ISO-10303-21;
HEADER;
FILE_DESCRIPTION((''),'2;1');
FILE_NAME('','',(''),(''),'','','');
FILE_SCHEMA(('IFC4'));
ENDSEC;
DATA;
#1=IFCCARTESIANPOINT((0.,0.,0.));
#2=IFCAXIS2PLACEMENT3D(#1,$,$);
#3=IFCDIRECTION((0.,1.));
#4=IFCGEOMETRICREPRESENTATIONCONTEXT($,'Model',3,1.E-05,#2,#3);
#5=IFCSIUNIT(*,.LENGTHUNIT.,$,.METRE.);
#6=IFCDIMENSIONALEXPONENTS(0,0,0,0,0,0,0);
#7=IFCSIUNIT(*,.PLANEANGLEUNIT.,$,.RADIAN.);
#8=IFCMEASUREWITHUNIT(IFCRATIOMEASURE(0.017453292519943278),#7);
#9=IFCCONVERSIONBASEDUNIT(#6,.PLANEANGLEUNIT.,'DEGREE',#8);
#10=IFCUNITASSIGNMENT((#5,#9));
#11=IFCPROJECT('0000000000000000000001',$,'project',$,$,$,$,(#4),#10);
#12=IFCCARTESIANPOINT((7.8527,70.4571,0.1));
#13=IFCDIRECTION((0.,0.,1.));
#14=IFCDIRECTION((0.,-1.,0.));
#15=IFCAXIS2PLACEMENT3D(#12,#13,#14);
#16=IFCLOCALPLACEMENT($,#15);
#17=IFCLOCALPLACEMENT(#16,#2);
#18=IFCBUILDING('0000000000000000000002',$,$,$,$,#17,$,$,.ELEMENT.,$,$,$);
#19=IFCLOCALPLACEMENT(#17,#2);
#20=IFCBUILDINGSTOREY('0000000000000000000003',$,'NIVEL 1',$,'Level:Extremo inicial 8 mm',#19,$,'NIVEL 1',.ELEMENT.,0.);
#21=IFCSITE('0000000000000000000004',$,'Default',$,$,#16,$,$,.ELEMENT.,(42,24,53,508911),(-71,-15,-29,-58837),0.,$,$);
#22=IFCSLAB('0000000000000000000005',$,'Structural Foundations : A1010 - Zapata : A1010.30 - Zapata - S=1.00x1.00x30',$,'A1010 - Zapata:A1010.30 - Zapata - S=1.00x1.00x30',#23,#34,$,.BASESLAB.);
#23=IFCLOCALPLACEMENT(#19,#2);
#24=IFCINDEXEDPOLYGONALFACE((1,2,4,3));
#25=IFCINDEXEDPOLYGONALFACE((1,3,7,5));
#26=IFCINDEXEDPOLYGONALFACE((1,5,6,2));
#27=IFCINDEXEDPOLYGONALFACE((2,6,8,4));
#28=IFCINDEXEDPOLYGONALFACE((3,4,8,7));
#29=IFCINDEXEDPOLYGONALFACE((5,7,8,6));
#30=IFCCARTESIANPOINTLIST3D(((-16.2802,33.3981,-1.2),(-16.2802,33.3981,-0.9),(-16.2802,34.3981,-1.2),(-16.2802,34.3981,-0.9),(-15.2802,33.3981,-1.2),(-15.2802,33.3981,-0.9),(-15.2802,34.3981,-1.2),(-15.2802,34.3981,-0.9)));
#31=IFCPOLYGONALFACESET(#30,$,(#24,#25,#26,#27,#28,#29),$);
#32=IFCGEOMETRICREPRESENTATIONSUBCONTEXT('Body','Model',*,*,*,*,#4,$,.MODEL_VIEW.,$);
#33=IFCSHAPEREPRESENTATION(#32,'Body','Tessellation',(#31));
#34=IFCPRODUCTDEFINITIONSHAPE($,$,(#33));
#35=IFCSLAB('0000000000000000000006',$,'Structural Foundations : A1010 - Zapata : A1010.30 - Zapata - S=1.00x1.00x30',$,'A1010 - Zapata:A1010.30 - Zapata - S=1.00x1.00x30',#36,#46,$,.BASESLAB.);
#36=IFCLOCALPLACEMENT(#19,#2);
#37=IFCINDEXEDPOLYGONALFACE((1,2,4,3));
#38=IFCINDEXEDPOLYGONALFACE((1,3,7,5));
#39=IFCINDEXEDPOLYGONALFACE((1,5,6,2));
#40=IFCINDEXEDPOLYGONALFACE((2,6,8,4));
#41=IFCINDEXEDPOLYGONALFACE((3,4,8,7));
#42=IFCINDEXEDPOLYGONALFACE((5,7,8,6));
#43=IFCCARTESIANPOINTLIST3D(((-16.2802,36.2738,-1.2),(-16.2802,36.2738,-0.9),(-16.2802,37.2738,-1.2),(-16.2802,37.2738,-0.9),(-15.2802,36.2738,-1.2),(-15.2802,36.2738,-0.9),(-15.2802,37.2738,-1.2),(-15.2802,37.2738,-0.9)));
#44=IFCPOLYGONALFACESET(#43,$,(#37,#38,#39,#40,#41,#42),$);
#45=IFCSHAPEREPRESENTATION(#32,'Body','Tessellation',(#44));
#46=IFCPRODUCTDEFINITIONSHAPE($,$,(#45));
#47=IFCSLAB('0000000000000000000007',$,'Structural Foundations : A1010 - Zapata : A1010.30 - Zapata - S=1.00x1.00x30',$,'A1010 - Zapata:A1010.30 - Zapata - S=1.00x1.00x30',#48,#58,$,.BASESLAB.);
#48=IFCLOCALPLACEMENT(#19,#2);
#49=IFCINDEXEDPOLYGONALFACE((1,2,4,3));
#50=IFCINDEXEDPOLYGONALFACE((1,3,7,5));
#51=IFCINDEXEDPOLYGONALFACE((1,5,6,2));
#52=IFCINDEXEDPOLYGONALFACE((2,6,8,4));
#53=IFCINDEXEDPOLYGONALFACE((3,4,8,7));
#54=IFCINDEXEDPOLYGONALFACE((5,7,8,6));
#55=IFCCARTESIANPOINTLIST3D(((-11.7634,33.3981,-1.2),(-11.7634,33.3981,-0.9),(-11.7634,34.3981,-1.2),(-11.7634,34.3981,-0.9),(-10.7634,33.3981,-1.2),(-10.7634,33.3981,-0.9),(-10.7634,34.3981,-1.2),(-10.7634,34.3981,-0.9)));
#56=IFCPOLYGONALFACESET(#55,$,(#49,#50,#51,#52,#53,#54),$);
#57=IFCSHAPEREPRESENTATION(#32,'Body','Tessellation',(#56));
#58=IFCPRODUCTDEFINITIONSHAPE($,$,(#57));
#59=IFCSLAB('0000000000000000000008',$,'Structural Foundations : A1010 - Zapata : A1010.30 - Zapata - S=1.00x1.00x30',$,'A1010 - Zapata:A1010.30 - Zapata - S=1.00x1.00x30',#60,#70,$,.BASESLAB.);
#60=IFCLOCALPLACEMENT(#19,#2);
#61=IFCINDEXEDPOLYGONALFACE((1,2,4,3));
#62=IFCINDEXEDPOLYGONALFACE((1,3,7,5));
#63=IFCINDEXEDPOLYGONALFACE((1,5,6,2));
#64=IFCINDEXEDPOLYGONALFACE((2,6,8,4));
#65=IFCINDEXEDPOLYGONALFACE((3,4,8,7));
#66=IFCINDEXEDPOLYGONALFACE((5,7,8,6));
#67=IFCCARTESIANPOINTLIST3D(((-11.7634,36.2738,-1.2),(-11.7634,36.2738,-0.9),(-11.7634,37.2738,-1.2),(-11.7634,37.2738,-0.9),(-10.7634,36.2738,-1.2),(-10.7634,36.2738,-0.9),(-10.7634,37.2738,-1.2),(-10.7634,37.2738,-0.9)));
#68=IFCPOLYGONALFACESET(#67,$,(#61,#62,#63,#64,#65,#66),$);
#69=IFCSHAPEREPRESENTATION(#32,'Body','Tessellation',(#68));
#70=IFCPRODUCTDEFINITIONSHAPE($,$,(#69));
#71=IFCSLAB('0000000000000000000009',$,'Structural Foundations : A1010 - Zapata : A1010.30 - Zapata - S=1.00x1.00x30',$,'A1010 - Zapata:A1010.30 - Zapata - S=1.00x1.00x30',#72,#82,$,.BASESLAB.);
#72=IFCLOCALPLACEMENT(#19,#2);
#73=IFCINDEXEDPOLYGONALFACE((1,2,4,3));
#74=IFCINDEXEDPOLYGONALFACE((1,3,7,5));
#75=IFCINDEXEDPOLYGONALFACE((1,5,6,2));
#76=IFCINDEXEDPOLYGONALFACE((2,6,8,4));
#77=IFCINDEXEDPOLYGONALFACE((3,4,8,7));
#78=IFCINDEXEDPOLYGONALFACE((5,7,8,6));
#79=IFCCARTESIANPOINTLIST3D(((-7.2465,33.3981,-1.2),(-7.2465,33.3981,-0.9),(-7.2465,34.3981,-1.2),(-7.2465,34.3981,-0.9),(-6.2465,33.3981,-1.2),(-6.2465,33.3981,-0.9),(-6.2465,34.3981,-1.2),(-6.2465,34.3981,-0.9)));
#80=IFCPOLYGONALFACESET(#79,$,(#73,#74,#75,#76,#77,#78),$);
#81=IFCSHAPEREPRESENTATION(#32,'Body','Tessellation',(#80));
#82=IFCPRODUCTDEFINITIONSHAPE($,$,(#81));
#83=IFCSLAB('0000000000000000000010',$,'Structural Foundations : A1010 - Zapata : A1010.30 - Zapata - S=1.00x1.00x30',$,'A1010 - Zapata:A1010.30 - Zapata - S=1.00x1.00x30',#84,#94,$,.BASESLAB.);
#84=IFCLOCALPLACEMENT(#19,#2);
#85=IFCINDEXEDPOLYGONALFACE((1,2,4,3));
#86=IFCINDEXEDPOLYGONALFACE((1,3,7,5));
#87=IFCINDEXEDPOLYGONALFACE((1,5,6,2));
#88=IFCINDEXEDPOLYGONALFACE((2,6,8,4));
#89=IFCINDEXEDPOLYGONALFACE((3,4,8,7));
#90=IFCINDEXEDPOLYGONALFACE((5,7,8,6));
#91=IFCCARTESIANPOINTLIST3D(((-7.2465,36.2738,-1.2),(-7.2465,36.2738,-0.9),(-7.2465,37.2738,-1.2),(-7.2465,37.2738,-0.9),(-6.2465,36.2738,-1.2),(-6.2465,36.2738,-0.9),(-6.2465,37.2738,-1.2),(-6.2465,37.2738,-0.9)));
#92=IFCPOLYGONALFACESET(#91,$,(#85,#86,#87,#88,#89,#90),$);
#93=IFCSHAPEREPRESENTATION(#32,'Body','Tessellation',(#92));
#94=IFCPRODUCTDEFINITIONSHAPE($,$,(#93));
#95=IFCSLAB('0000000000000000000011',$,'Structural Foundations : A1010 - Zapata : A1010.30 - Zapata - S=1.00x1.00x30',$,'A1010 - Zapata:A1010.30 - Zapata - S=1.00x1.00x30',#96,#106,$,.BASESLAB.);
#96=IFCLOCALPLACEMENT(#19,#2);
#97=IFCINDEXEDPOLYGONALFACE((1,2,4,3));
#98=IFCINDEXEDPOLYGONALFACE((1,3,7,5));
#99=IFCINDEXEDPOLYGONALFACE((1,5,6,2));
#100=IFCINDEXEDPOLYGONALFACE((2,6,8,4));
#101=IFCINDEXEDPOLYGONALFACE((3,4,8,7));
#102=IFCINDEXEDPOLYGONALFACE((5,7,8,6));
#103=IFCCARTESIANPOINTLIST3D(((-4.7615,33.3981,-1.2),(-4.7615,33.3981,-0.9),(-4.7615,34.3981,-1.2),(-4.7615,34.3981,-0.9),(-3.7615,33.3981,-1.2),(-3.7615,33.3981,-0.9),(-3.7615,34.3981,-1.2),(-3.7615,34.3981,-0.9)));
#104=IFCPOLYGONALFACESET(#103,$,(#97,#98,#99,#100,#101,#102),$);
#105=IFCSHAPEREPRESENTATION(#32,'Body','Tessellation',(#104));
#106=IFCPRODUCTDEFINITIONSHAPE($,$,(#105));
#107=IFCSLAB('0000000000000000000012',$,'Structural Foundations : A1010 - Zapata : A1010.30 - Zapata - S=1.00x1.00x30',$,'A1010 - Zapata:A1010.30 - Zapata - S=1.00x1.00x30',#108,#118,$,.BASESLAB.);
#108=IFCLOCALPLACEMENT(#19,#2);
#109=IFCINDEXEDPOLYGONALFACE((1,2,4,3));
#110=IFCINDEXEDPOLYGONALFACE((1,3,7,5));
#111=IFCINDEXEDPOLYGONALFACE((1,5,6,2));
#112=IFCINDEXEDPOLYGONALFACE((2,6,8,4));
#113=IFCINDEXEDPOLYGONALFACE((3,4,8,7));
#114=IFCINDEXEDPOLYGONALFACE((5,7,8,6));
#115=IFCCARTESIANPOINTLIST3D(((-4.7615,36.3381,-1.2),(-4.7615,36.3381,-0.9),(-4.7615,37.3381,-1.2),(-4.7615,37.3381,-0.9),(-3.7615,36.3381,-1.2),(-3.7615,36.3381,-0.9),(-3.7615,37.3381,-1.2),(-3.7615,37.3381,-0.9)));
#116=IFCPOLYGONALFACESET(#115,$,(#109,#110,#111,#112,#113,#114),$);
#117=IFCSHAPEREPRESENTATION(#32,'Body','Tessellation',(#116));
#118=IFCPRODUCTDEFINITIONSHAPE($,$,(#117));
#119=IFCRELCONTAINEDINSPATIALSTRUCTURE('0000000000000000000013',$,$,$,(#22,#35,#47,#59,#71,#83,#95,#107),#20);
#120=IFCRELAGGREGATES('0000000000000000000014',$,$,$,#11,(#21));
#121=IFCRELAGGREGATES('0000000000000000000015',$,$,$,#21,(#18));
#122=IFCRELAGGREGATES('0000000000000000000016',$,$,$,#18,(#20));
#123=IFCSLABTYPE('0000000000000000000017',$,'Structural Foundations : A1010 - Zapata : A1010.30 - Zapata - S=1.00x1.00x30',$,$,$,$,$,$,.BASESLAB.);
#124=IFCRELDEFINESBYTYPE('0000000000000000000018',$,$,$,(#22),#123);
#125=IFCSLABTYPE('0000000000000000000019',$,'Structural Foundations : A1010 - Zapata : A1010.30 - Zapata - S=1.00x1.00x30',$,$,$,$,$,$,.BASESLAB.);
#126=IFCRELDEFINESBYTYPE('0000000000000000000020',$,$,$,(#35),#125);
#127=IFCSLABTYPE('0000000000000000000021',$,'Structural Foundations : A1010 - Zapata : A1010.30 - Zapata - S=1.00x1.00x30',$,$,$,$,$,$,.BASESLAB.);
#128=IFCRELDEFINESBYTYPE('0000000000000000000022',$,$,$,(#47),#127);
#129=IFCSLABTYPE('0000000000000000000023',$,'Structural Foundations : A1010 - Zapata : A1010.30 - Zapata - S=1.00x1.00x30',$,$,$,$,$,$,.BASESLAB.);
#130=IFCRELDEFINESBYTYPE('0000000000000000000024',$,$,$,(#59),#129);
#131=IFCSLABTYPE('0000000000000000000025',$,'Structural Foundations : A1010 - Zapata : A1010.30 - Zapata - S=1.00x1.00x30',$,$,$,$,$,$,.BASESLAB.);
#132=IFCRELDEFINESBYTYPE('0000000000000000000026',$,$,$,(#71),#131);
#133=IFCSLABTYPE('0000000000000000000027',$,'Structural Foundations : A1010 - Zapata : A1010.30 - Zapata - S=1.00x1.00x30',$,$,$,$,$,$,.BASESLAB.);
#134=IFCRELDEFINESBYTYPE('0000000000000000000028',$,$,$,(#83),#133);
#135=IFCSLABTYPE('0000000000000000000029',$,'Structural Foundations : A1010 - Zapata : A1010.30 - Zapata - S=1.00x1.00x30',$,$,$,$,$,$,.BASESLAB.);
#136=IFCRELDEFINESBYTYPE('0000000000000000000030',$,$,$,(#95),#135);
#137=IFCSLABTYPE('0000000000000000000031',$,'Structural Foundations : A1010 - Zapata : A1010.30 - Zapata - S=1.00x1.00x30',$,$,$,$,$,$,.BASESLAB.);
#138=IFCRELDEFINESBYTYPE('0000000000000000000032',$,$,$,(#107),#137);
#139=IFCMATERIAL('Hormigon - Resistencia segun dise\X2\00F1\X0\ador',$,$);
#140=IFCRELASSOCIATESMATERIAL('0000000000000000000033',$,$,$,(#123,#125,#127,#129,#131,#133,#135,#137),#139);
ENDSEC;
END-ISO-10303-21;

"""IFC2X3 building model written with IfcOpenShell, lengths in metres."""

from ifc_helpers import new_model, entity, si_unit, converted_unit, direction, frame, frame_2d, origin, origin_2d_with_axis, place, context, subcontext, project, spatial, rectangle, extrude, material, type_object, element, save


model = new_model("IFC2X3")

# Units and contexts
model_context = context("Model", 3, precision=1e-05, world=origin(), true_north=direction((0.0, 1.0)))
body_context = subcontext(model_context, "Body", "Model", "MODEL_VIEW")
ifc_project = project(units=[si_unit("LENGTHUNIT", "METRE"), converted_unit("PLANEANGLEUNIT", "DEGREE", entity("IfcRatioMeasure", 0.017453292519943278), si_unit("PLANEANGLEUNIT", "RADIAN"), dimensions=[0, 0, 0, 0, 0, 0, 0])], contexts=[model_context])

# Site, building, storey
site_placement = place(None, frame((7.8527, 70.4571, 0.1), z_axis=(0.0, 0.0, 1.0), x_axis=(0.0, -1.0, 0.0)))
site = spatial("IfcSite", under=ifc_project, at=site_placement, Name="Default", CompositionType="ELEMENT", RefLatitude=(42, 24, 53, 508911), RefLongitude=(-71, -15, -29, -58837), RefElevation=0.0)
building_placement = place(site_placement, origin())
building = spatial("IfcBuilding", under=site, at=building_placement, CompositionType="ELEMENT")
storey_placement = place(building_placement, origin())
storey = spatial("IfcBuildingStorey", under=building, at=storey_placement, Name="NIVEL 1", ObjectType="Level:Extremo inicial 8 mm", LongName="NIVEL 1", CompositionType="ELEMENT", Elevation=0.0)

# Slabs
ifc_material = material(Name="Hormigon - Resistencia segun diseñador")
slab_type_1 = type_object("IfcSlabType", Name="Structural Foundations : A1010 - Zapata : A1010.30 - Zapata - S=1.00x1.00x30", PredefinedType="BASESLAB", material=ifc_material)
slab_1_placement = place(storey_placement, origin())
element("IfcSlab", 1, at=slab_1_placement, inside=storey, type_object=slab_type_1, Name="Structural Foundations : A1010 - Zapata : A1010.30 - Zapata - S=1.00x1.00x30", ObjectType="A1010 - Zapata:A1010.30 - Zapata - S=1.00x1.00x30", PredefinedType="BASESLAB", context=body_context, shape_type="SweptSolid", body=[
    extrude(rectangle(XDim=1.0, YDim=1.0, at=frame_2d((0.0, 0.0), x_axis=(1.0, 0.0))), frame((-15.7802, 33.8981, -1.2), z_axis=(0.0, 0.0, 1.0), x_axis=(-1.0, 0.0, 0.0)), (0.0, 0.0, 1.0), 0.3),
])
slab_type_2 = type_object("IfcSlabType", Name="Structural Foundations : A1010 - Zapata : A1010.30 - Zapata - S=1.00x1.00x30", PredefinedType="BASESLAB", material=ifc_material)
slab_2_placement = place(storey_placement, origin())
element("IfcSlab", 2, at=slab_2_placement, inside=storey, type_object=slab_type_2, Name="Structural Foundations : A1010 - Zapata : A1010.30 - Zapata - S=1.00x1.00x30", ObjectType="A1010 - Zapata:A1010.30 - Zapata - S=1.00x1.00x30", PredefinedType="BASESLAB", context=body_context, shape_type="SweptSolid", body=[
    extrude(rectangle(XDim=1.0, YDim=1.0, at=frame_2d((0.0, 0.0), x_axis=(1.0, 0.0))), frame((-15.7802, 36.7738, -1.2), z_axis=(0.0, 0.0, 1.0), x_axis=(-1.0, 0.0, 0.0)), (0.0, 0.0, 1.0), 0.3),
])
slab_type_3 = type_object("IfcSlabType", Name="Structural Foundations : A1010 - Zapata : A1010.30 - Zapata - S=1.00x1.00x30", PredefinedType="BASESLAB", material=ifc_material)
slab_3_placement = place(storey_placement, origin())
element("IfcSlab", 3, at=slab_3_placement, inside=storey, type_object=slab_type_3, Name="Structural Foundations : A1010 - Zapata : A1010.30 - Zapata - S=1.00x1.00x30", ObjectType="A1010 - Zapata:A1010.30 - Zapata - S=1.00x1.00x30", PredefinedType="BASESLAB", context=body_context, shape_type="SweptSolid", body=[
    extrude(rectangle(XDim=1.0, YDim=1.0, at=frame_2d((0.0, 0.0), x_axis=(1.0, 0.0))), frame((-11.2634, 33.8981, -1.2), z_axis=(0.0, 0.0, 1.0), x_axis=(-1.0, 0.0, 0.0)), (0.0, 0.0, 1.0), 0.3),
])
slab_type_4 = type_object("IfcSlabType", Name="Structural Foundations : A1010 - Zapata : A1010.30 - Zapata - S=1.00x1.00x30", PredefinedType="BASESLAB", material=ifc_material)
slab_4_placement = place(storey_placement, origin())
element("IfcSlab", 4, at=slab_4_placement, inside=storey, type_object=slab_type_4, Name="Structural Foundations : A1010 - Zapata : A1010.30 - Zapata - S=1.00x1.00x30", ObjectType="A1010 - Zapata:A1010.30 - Zapata - S=1.00x1.00x30", PredefinedType="BASESLAB", context=body_context, shape_type="SweptSolid", body=[
    extrude(rectangle(XDim=1.0, YDim=1.0, at=frame_2d((0.0, 0.0), x_axis=(1.0, 0.0))), frame((-11.2634, 36.7738, -1.2), z_axis=(0.0, 0.0, 1.0), x_axis=(-1.0, 0.0, 0.0)), (0.0, 0.0, 1.0), 0.3),
])
slab_type_5 = type_object("IfcSlabType", Name="Structural Foundations : A1010 - Zapata : A1010.30 - Zapata - S=1.00x1.00x30", PredefinedType="BASESLAB", material=ifc_material)
slab_5_placement = place(storey_placement, origin())
element("IfcSlab", 5, at=slab_5_placement, inside=storey, type_object=slab_type_5, Name="Structural Foundations : A1010 - Zapata : A1010.30 - Zapata - S=1.00x1.00x30", ObjectType="A1010 - Zapata:A1010.30 - Zapata - S=1.00x1.00x30", PredefinedType="BASESLAB", context=body_context, shape_type="SweptSolid", body=[
    extrude(rectangle(XDim=1.0, YDim=1.0, at=origin_2d_with_axis()), frame((-6.7465, 33.8981, -1.2), z_axis=(0.0, 0.0, 1.0), x_axis=(-1.0, 0.0, 0.0)), (0.0, 0.0, 1.0), 0.3),
])
slab_type_6 = type_object("IfcSlabType", Name="Structural Foundations : A1010 - Zapata : A1010.30 - Zapata - S=1.00x1.00x30", PredefinedType="BASESLAB", material=ifc_material)
slab_6_placement = place(storey_placement, origin())
element("IfcSlab", 6, at=slab_6_placement, inside=storey, type_object=slab_type_6, Name="Structural Foundations : A1010 - Zapata : A1010.30 - Zapata - S=1.00x1.00x30", ObjectType="A1010 - Zapata:A1010.30 - Zapata - S=1.00x1.00x30", PredefinedType="BASESLAB", context=body_context, shape_type="SweptSolid", body=[
    extrude(rectangle(XDim=1.0, YDim=1.0, at=origin_2d_with_axis()), frame((-6.7465, 36.7738, -1.2), z_axis=(0.0, 0.0, 1.0), x_axis=(-1.0, 0.0, 0.0)), (0.0, 0.0, 1.0), 0.3),
])
slab_type_7 = type_object("IfcSlabType", Name="Structural Foundations : A1010 - Zapata : A1010.30 - Zapata - S=1.00x1.00x30", PredefinedType="BASESLAB", material=ifc_material)
slab_7_placement = place(storey_placement, origin())
element("IfcSlab", 7, at=slab_7_placement, inside=storey, type_object=slab_type_7, Name="Structural Foundations : A1010 - Zapata : A1010.30 - Zapata - S=1.00x1.00x30", ObjectType="A1010 - Zapata:A1010.30 - Zapata - S=1.00x1.00x30", PredefinedType="BASESLAB", context=body_context, shape_type="SweptSolid", body=[
    extrude(rectangle(XDim=1.0, YDim=1.0, at=frame_2d((0.0, 0.0), x_axis=(1.0, 0.0))), frame((-4.2615, 33.8981, -1.2), z_axis=(0.0, 0.0, 1.0), x_axis=(-1.0, 0.0, 0.0)), (0.0, 0.0, 1.0), 0.3),
])
slab_type_8 = type_object("IfcSlabType", Name="Structural Foundations : A1010 - Zapata : A1010.30 - Zapata - S=1.00x1.00x30", PredefinedType="BASESLAB", material=ifc_material)
slab_8_placement = place(storey_placement, origin())
element("IfcSlab", 8, at=slab_8_placement, inside=storey, type_object=slab_type_8, Name="Structural Foundations : A1010 - Zapata : A1010.30 - Zapata - S=1.00x1.00x30", ObjectType="A1010 - Zapata:A1010.30 - Zapata - S=1.00x1.00x30", PredefinedType="BASESLAB", context=body_context, shape_type="SweptSolid", body=[
    extrude(rectangle(XDim=1.0, YDim=1.0, at=frame_2d((0.0, 0.0), x_axis=(1.0, 0.0))), frame((-4.2615, 36.8381, -1.2), z_axis=(0.0, 0.0, 1.0), x_axis=(-1.0, 0.0, 0.0)), (0.0, 0.0, 1.0), 0.3),
])

save(model, "model.ifc")
